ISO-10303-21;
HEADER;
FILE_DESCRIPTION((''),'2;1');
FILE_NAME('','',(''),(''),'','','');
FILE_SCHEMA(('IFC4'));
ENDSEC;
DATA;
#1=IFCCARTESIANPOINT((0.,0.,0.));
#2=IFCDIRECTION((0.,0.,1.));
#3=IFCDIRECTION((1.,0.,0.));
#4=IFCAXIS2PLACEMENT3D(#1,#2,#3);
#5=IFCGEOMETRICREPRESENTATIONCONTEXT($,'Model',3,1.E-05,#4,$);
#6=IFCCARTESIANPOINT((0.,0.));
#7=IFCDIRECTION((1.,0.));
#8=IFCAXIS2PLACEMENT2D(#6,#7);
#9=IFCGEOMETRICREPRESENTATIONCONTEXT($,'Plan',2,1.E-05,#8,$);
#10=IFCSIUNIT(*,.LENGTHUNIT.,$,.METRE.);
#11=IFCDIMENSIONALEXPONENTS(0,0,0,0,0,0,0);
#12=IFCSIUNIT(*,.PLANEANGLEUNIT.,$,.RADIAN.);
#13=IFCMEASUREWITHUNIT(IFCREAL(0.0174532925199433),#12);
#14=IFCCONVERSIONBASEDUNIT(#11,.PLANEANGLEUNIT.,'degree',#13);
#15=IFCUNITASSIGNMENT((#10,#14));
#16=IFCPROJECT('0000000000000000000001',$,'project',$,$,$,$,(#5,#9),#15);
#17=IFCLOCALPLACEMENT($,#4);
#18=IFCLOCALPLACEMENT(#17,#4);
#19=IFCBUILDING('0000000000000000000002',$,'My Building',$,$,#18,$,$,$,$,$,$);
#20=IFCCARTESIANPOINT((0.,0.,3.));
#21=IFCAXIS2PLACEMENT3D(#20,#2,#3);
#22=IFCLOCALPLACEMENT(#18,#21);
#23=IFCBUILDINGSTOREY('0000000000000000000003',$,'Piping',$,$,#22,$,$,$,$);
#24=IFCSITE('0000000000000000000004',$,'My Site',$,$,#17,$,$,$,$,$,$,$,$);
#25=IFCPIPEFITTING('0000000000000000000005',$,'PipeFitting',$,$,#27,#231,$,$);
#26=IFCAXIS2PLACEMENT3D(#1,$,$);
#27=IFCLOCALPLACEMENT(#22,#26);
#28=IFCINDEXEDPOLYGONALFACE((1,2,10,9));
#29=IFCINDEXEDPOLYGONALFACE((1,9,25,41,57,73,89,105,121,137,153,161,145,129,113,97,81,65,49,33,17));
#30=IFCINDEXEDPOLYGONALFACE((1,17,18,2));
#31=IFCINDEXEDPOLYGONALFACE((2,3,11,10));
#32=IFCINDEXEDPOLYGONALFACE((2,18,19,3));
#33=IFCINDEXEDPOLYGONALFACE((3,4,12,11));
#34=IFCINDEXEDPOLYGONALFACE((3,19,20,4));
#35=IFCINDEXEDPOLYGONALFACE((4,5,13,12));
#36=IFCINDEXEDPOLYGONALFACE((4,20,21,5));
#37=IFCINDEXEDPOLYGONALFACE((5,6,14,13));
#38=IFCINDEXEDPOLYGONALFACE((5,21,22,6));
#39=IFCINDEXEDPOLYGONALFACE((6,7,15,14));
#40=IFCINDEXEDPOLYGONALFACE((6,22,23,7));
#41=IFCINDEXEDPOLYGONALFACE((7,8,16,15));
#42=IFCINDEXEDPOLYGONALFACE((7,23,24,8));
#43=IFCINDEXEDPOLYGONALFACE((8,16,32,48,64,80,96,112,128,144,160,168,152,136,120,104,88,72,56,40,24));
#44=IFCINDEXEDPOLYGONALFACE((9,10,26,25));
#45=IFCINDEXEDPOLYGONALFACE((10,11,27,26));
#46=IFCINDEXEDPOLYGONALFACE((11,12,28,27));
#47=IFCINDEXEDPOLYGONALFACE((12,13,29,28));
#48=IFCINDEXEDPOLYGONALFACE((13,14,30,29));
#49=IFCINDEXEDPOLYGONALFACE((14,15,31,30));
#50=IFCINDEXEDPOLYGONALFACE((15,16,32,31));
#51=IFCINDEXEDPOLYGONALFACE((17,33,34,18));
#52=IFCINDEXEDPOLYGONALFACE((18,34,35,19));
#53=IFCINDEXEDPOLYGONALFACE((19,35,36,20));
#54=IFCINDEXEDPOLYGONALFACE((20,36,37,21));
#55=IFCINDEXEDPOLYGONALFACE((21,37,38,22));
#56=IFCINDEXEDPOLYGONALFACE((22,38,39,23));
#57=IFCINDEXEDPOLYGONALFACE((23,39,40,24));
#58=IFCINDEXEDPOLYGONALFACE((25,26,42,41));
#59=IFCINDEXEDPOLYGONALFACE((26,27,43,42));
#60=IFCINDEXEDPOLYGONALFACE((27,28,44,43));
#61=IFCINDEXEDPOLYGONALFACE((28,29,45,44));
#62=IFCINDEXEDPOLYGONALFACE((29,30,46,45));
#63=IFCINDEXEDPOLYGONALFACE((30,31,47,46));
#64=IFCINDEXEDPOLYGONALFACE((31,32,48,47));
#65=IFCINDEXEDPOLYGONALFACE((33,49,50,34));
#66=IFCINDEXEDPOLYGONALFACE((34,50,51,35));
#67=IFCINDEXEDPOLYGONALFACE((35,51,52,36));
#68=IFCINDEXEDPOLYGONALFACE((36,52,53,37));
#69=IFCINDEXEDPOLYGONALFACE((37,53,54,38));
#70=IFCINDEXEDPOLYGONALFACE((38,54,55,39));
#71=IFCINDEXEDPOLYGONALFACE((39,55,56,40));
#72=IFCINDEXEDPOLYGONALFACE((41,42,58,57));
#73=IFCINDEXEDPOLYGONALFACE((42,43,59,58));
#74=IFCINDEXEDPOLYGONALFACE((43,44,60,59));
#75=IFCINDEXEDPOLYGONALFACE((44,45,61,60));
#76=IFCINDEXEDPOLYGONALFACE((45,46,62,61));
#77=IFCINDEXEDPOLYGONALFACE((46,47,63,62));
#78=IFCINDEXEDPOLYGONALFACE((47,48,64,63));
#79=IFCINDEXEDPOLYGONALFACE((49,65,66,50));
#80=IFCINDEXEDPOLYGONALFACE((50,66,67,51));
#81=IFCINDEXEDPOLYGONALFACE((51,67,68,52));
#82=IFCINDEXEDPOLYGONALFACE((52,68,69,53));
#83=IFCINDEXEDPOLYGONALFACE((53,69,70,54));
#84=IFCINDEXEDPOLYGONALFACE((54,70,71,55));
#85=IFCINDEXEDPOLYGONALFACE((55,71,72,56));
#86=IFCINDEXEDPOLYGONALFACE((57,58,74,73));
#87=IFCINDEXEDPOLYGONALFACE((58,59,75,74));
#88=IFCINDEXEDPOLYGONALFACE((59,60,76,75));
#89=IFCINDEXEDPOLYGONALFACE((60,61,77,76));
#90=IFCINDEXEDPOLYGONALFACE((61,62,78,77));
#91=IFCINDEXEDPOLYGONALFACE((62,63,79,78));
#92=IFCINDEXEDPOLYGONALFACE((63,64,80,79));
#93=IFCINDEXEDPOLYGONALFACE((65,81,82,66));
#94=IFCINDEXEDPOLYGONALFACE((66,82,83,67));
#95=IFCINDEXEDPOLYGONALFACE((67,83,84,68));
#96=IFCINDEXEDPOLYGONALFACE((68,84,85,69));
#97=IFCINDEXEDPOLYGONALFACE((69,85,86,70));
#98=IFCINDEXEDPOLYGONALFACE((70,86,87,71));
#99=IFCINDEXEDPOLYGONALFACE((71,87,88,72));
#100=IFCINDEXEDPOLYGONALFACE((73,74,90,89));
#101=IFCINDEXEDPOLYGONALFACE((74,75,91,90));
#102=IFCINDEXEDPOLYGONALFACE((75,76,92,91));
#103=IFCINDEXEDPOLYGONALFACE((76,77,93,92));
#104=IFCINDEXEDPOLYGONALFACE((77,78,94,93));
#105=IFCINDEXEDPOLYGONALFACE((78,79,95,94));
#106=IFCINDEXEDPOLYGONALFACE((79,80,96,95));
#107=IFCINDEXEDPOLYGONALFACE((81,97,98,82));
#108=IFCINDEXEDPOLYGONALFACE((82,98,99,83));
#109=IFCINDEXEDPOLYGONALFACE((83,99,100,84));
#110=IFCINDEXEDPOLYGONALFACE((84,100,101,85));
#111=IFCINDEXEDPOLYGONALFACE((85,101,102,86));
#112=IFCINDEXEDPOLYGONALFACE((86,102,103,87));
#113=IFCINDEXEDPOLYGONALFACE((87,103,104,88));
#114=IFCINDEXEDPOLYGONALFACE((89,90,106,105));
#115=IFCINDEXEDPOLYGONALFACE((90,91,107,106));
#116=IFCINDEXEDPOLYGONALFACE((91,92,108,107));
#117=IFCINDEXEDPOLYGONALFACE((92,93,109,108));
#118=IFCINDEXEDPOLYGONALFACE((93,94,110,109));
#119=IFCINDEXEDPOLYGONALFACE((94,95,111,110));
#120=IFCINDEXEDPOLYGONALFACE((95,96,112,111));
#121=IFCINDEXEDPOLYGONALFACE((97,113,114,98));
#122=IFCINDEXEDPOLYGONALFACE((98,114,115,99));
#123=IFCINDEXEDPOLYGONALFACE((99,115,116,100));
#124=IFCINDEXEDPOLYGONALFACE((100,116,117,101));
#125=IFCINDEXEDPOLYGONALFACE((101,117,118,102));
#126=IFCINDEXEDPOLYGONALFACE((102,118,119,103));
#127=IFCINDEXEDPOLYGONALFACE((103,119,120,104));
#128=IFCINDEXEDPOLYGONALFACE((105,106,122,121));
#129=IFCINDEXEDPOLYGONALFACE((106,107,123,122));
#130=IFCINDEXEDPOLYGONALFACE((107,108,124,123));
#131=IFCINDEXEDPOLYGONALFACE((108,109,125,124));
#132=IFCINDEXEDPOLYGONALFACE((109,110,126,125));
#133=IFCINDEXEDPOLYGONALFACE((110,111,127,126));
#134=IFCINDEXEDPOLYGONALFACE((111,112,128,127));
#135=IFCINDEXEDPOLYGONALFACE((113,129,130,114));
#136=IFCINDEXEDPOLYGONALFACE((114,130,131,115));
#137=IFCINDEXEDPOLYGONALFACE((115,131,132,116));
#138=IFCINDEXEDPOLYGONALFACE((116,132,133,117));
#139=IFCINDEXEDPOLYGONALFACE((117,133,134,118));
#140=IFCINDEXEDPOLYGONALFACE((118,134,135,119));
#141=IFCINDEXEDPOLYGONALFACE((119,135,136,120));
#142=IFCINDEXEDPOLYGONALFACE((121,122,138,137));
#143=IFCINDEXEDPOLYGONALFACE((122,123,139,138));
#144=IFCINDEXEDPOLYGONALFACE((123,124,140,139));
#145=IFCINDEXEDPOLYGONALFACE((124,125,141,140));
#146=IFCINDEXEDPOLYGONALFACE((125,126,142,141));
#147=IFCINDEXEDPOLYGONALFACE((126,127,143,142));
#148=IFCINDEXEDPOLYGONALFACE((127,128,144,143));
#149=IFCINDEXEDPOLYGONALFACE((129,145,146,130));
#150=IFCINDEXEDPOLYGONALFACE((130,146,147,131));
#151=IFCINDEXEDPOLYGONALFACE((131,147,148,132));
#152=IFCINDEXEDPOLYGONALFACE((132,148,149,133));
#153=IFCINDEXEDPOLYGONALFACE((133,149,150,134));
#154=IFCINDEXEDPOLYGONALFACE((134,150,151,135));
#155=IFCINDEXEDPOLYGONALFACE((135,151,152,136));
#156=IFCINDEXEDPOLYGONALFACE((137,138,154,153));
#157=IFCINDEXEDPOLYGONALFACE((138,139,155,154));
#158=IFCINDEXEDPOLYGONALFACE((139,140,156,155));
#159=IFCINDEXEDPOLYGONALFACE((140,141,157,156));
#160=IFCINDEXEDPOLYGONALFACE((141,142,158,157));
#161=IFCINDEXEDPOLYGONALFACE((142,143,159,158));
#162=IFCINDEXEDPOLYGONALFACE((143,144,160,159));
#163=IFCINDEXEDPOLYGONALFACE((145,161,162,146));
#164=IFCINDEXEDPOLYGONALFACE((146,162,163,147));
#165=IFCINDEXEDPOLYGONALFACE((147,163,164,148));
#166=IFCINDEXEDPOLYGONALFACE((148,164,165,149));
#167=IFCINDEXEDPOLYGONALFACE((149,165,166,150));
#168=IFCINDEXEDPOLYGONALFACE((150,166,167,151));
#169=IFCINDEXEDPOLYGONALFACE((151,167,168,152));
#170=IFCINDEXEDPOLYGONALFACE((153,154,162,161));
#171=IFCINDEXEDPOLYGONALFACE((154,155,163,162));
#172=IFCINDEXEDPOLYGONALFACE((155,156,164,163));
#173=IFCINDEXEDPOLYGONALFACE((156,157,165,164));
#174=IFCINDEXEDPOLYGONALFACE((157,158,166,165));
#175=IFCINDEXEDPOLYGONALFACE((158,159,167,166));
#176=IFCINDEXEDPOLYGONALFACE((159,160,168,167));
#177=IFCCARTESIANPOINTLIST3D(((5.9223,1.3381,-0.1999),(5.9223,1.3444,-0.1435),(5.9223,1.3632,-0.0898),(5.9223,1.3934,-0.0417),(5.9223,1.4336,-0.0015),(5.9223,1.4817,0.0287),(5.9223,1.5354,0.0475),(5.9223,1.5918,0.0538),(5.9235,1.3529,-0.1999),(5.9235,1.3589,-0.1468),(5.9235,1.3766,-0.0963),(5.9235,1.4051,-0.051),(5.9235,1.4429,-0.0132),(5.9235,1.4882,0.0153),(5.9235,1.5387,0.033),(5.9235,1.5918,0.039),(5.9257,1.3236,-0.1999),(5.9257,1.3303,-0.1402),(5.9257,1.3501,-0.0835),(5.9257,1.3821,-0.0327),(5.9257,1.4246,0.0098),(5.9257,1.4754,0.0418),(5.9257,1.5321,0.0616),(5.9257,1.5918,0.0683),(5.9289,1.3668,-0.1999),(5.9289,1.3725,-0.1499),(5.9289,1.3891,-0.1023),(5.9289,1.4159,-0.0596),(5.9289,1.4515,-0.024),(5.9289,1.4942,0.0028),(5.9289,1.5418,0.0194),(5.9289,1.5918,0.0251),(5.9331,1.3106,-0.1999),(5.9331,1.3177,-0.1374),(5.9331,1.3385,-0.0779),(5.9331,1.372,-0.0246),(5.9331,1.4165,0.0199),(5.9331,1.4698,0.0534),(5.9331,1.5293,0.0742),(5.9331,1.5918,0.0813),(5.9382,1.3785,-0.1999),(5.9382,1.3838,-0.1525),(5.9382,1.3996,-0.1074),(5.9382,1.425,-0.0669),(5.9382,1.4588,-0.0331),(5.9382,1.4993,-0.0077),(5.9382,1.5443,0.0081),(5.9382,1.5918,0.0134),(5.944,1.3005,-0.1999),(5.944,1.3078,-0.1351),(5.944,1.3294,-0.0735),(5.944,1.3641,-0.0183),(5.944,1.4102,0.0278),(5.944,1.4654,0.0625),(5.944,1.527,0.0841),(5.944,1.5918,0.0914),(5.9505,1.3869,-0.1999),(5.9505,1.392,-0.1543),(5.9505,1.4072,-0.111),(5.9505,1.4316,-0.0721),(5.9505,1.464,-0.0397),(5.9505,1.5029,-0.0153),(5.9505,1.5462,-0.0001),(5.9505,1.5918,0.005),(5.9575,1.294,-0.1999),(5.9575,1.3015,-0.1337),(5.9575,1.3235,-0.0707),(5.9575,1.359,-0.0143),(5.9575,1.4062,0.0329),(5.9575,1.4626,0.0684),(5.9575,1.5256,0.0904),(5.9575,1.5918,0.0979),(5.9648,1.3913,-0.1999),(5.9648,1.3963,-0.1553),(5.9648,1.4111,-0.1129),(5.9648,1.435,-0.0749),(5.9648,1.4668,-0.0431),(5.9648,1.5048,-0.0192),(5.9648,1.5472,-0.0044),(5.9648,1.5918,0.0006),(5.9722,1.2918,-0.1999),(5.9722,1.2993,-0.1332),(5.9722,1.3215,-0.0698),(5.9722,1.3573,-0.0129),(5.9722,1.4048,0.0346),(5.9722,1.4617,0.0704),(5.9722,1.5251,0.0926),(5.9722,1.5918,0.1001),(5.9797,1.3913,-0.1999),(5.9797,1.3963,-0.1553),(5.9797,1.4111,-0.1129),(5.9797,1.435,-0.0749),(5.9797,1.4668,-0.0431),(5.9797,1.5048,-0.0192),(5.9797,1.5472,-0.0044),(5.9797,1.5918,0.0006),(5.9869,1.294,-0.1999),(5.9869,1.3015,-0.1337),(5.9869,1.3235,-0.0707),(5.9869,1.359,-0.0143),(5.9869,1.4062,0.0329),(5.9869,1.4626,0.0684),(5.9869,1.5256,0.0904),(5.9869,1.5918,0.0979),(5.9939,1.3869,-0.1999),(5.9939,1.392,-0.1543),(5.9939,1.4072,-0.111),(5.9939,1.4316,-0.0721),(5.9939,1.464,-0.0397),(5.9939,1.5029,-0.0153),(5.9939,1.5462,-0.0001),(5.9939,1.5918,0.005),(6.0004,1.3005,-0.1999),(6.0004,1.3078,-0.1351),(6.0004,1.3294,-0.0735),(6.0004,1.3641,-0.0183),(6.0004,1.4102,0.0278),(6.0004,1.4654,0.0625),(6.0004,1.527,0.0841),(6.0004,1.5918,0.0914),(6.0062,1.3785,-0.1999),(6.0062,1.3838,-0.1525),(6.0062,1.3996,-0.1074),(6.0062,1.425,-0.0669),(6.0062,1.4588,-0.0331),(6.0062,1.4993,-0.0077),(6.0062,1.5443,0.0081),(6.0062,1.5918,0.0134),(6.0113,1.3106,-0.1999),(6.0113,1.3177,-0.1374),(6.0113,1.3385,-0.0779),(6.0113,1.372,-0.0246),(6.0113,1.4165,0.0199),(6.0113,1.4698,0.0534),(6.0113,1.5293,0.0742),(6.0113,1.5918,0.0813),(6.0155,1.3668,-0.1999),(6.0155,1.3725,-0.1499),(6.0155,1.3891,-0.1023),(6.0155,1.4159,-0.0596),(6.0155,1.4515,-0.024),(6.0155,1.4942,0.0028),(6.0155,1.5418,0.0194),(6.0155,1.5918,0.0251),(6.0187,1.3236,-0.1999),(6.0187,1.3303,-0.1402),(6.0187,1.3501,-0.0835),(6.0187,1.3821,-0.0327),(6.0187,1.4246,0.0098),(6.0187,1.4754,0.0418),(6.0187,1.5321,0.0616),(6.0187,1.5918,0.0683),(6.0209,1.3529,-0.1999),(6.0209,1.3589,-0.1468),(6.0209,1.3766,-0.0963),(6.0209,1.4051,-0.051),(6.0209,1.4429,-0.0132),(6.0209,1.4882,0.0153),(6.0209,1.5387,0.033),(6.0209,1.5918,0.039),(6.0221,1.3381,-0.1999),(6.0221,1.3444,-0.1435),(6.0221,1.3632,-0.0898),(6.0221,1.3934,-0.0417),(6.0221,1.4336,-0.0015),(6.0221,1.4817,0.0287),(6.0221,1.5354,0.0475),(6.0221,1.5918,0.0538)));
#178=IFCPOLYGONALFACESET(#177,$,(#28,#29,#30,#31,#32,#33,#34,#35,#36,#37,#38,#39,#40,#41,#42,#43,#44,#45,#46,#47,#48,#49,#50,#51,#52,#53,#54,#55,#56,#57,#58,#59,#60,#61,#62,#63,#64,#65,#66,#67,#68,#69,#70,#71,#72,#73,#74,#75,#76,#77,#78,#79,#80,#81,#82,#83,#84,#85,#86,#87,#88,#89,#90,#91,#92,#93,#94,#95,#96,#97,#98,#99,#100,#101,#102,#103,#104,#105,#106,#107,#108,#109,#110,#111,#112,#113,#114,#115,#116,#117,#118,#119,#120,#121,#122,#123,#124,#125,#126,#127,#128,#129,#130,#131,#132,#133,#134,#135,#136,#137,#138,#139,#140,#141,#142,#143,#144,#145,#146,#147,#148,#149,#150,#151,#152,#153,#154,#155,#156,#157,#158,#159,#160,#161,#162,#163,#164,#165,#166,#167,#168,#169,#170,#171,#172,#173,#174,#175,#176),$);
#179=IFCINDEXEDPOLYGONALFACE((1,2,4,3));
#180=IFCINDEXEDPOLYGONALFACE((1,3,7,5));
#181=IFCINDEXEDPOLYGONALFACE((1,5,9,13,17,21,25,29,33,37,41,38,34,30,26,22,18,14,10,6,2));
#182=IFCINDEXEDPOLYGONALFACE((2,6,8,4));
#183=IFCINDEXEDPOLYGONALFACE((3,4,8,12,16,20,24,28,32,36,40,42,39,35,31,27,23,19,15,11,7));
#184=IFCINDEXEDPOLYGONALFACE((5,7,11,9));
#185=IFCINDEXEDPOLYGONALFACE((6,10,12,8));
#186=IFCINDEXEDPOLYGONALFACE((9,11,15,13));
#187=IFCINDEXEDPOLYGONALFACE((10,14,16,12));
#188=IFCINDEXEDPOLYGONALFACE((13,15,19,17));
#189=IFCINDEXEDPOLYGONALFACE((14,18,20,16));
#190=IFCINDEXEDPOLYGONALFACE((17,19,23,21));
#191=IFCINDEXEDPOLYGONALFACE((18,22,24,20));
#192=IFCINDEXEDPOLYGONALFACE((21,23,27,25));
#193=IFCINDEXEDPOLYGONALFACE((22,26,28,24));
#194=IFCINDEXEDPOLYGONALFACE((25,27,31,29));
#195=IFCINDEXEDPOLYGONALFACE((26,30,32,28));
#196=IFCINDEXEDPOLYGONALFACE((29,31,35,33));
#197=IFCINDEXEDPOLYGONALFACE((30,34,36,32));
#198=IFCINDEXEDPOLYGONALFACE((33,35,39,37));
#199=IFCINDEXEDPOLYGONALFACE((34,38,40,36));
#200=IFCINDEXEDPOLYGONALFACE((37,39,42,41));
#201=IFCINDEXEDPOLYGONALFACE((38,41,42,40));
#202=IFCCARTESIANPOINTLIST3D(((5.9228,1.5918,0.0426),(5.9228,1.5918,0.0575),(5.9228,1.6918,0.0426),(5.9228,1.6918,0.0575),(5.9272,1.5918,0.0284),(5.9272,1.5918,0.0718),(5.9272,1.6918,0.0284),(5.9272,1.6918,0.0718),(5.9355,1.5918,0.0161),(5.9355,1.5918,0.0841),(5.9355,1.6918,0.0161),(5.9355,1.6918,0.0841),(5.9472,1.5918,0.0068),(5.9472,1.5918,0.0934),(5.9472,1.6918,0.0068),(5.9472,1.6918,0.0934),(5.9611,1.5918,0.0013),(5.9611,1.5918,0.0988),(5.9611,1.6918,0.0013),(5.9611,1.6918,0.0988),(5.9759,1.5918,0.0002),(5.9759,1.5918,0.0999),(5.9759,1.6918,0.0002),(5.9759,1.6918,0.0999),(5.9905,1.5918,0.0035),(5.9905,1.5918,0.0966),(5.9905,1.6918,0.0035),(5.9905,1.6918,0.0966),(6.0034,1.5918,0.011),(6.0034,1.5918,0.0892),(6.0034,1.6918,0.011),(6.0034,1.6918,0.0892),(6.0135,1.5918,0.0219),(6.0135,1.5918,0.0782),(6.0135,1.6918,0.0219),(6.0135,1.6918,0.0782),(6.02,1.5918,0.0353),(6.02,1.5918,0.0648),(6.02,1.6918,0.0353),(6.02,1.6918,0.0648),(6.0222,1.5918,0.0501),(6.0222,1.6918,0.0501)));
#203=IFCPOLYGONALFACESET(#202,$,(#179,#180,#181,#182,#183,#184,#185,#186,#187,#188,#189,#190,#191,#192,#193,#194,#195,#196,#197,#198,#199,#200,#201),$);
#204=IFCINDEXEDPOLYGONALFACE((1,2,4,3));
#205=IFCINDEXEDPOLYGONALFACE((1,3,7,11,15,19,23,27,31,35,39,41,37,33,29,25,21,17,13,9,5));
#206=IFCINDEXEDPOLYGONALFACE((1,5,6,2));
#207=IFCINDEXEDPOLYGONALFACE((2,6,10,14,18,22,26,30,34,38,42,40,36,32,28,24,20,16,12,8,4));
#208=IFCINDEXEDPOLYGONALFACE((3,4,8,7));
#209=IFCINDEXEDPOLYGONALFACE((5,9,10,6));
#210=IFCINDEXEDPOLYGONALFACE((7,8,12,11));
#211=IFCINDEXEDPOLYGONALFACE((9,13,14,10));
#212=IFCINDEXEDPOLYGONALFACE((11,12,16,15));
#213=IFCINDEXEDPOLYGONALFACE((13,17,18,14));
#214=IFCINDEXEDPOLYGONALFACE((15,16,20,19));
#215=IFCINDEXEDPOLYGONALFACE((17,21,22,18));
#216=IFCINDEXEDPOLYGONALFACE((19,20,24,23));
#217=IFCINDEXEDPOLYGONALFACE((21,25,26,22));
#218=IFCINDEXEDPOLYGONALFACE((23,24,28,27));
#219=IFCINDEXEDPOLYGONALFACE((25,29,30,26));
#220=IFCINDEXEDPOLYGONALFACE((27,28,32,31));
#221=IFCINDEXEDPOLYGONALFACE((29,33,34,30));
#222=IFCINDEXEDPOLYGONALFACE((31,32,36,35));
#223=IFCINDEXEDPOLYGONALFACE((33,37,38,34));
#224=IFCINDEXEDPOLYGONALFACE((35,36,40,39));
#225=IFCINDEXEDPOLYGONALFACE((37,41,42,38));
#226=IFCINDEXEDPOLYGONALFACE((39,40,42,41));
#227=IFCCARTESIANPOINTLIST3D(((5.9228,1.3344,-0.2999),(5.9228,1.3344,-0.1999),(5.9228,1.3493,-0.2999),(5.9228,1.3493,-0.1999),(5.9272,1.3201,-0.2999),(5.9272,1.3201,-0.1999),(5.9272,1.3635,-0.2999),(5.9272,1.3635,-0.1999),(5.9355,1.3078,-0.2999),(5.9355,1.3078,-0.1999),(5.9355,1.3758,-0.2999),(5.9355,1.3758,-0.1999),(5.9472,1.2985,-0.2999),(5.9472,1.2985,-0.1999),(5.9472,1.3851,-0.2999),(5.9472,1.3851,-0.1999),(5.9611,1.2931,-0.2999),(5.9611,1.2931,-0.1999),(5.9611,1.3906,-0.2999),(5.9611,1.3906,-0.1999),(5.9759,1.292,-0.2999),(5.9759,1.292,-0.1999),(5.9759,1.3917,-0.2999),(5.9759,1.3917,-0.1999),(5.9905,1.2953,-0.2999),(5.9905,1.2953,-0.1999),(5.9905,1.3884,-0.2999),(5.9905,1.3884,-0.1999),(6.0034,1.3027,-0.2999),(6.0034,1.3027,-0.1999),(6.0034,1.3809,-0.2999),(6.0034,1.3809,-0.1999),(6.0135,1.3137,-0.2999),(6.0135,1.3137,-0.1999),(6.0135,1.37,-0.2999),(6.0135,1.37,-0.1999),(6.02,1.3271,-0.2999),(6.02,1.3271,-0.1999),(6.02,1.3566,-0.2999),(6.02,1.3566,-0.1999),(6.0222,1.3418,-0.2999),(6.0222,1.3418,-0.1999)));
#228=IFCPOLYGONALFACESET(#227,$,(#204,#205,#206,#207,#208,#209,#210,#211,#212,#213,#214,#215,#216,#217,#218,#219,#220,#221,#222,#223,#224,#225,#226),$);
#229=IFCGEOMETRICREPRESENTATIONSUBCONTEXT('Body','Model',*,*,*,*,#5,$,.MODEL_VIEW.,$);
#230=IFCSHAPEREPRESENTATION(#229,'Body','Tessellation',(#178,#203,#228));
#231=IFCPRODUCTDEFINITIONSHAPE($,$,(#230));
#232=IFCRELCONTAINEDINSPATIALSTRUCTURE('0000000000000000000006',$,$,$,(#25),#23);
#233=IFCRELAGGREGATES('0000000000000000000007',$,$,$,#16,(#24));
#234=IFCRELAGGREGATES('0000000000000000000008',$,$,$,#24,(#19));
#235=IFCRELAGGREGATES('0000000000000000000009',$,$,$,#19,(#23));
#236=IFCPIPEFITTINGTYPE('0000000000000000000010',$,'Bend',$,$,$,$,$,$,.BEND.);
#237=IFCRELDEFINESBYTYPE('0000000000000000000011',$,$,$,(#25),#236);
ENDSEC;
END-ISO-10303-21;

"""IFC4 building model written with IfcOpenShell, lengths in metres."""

from ifc_helpers import new_model, entity, si_unit, converted_unit, frame, origin_with_axes, origin_2d_with_axis, place, context, subcontext, project, spatial, circle, extrude, source, transform, mapped, type_object, type_shapes, element, save


model = new_model("IFC4")

# Units and contexts
model_context = context("Model", 3, precision=1e-05, world=origin_with_axes())
plan_context = context("Plan", 2, precision=1e-05, world=origin_2d_with_axis())
body_context = subcontext(model_context, "Body", "Model", "MODEL_VIEW")
ifc_project = project(units=[si_unit("LENGTHUNIT", "METRE"), converted_unit("PLANEANGLEUNIT", "degree", entity("IfcReal", 0.0174532925199433), si_unit("PLANEANGLEUNIT", "RADIAN"), dimensions=[0, 0, 0, 0, 0, 0, 0])], contexts=[model_context, plan_context])

# Site, building, storey
site_placement = place(None, origin_with_axes())
site = spatial("IfcSite", under=ifc_project, at=site_placement, Name="My Site")
building_placement = place(site_placement, origin_with_axes())
building = spatial("IfcBuilding", under=site, at=building_placement, Name="My Building")
storey_placement = place(building_placement, frame((0.0, 0.0, 3.0), z_axis=(0.0, 0.0, 1.0), x_axis=(1.0, 0.0, 0.0)))
storey = spatial("IfcBuildingStorey", under=building, at=storey_placement, Name="Piping")

# Pipe fitting
pipe_fitting_type_1 = type_object("IfcPipeFittingType", Name="Bend", PredefinedType="BEND")
shared_shape = source(origin_with_axes(), body_context, "Body", "SolidModel", [
    entity("IfcSweptDiskSolid", entity("IfcIndexedPolyCurve", entity("IfcCartesianPointList3D", [[0.0, 0.0, 0.1], [0.0, -0.0732, 0.2768], [0.0, -0.25, 0.35]]), [entity("IfcArcIndex", [1, 2, 3])]), 0.05),
    extrude(circle(Radius=0.05), origin_with_axes(), (0.0, 0.0, 1.0), 0.1),
    extrude(circle(Radius=0.05), frame((0.0, -0.25, 0.35), z_axis=(0.0, -1.0, -0.000003), x_axis=(1.0, 0.0, 0.0)), (0.0, 0.0, 1.0), 0.1),
])
type_shapes(pipe_fitting_type_1, [shared_shape])
for number, where, z_axis, x_axis, name in (
    (1, (5.9722, 1.6918, 0.0501), (0.0, -1.0, 0.0), (1.0, 0.0, 0.0), "PipeFitting"),
):
    element("IfcPipeFitting", number, at=place(storey_placement, frame(where, z_axis=z_axis, x_axis=x_axis)), inside=storey, type_object=pipe_fitting_type_1, Name=name, context=body_context, shape_type="MappedRepresentation", body=[
        mapped(shared_shape, transform((0.0, 0.0, 0.0), x_axis=(1.0, 0.0, 0.0), y_axis=(0.0, 1.0, 0.0), z_axis=(0.0, 0.0, 1.0), scale=1.0)),
    ])

save(model, "model.ifc")
